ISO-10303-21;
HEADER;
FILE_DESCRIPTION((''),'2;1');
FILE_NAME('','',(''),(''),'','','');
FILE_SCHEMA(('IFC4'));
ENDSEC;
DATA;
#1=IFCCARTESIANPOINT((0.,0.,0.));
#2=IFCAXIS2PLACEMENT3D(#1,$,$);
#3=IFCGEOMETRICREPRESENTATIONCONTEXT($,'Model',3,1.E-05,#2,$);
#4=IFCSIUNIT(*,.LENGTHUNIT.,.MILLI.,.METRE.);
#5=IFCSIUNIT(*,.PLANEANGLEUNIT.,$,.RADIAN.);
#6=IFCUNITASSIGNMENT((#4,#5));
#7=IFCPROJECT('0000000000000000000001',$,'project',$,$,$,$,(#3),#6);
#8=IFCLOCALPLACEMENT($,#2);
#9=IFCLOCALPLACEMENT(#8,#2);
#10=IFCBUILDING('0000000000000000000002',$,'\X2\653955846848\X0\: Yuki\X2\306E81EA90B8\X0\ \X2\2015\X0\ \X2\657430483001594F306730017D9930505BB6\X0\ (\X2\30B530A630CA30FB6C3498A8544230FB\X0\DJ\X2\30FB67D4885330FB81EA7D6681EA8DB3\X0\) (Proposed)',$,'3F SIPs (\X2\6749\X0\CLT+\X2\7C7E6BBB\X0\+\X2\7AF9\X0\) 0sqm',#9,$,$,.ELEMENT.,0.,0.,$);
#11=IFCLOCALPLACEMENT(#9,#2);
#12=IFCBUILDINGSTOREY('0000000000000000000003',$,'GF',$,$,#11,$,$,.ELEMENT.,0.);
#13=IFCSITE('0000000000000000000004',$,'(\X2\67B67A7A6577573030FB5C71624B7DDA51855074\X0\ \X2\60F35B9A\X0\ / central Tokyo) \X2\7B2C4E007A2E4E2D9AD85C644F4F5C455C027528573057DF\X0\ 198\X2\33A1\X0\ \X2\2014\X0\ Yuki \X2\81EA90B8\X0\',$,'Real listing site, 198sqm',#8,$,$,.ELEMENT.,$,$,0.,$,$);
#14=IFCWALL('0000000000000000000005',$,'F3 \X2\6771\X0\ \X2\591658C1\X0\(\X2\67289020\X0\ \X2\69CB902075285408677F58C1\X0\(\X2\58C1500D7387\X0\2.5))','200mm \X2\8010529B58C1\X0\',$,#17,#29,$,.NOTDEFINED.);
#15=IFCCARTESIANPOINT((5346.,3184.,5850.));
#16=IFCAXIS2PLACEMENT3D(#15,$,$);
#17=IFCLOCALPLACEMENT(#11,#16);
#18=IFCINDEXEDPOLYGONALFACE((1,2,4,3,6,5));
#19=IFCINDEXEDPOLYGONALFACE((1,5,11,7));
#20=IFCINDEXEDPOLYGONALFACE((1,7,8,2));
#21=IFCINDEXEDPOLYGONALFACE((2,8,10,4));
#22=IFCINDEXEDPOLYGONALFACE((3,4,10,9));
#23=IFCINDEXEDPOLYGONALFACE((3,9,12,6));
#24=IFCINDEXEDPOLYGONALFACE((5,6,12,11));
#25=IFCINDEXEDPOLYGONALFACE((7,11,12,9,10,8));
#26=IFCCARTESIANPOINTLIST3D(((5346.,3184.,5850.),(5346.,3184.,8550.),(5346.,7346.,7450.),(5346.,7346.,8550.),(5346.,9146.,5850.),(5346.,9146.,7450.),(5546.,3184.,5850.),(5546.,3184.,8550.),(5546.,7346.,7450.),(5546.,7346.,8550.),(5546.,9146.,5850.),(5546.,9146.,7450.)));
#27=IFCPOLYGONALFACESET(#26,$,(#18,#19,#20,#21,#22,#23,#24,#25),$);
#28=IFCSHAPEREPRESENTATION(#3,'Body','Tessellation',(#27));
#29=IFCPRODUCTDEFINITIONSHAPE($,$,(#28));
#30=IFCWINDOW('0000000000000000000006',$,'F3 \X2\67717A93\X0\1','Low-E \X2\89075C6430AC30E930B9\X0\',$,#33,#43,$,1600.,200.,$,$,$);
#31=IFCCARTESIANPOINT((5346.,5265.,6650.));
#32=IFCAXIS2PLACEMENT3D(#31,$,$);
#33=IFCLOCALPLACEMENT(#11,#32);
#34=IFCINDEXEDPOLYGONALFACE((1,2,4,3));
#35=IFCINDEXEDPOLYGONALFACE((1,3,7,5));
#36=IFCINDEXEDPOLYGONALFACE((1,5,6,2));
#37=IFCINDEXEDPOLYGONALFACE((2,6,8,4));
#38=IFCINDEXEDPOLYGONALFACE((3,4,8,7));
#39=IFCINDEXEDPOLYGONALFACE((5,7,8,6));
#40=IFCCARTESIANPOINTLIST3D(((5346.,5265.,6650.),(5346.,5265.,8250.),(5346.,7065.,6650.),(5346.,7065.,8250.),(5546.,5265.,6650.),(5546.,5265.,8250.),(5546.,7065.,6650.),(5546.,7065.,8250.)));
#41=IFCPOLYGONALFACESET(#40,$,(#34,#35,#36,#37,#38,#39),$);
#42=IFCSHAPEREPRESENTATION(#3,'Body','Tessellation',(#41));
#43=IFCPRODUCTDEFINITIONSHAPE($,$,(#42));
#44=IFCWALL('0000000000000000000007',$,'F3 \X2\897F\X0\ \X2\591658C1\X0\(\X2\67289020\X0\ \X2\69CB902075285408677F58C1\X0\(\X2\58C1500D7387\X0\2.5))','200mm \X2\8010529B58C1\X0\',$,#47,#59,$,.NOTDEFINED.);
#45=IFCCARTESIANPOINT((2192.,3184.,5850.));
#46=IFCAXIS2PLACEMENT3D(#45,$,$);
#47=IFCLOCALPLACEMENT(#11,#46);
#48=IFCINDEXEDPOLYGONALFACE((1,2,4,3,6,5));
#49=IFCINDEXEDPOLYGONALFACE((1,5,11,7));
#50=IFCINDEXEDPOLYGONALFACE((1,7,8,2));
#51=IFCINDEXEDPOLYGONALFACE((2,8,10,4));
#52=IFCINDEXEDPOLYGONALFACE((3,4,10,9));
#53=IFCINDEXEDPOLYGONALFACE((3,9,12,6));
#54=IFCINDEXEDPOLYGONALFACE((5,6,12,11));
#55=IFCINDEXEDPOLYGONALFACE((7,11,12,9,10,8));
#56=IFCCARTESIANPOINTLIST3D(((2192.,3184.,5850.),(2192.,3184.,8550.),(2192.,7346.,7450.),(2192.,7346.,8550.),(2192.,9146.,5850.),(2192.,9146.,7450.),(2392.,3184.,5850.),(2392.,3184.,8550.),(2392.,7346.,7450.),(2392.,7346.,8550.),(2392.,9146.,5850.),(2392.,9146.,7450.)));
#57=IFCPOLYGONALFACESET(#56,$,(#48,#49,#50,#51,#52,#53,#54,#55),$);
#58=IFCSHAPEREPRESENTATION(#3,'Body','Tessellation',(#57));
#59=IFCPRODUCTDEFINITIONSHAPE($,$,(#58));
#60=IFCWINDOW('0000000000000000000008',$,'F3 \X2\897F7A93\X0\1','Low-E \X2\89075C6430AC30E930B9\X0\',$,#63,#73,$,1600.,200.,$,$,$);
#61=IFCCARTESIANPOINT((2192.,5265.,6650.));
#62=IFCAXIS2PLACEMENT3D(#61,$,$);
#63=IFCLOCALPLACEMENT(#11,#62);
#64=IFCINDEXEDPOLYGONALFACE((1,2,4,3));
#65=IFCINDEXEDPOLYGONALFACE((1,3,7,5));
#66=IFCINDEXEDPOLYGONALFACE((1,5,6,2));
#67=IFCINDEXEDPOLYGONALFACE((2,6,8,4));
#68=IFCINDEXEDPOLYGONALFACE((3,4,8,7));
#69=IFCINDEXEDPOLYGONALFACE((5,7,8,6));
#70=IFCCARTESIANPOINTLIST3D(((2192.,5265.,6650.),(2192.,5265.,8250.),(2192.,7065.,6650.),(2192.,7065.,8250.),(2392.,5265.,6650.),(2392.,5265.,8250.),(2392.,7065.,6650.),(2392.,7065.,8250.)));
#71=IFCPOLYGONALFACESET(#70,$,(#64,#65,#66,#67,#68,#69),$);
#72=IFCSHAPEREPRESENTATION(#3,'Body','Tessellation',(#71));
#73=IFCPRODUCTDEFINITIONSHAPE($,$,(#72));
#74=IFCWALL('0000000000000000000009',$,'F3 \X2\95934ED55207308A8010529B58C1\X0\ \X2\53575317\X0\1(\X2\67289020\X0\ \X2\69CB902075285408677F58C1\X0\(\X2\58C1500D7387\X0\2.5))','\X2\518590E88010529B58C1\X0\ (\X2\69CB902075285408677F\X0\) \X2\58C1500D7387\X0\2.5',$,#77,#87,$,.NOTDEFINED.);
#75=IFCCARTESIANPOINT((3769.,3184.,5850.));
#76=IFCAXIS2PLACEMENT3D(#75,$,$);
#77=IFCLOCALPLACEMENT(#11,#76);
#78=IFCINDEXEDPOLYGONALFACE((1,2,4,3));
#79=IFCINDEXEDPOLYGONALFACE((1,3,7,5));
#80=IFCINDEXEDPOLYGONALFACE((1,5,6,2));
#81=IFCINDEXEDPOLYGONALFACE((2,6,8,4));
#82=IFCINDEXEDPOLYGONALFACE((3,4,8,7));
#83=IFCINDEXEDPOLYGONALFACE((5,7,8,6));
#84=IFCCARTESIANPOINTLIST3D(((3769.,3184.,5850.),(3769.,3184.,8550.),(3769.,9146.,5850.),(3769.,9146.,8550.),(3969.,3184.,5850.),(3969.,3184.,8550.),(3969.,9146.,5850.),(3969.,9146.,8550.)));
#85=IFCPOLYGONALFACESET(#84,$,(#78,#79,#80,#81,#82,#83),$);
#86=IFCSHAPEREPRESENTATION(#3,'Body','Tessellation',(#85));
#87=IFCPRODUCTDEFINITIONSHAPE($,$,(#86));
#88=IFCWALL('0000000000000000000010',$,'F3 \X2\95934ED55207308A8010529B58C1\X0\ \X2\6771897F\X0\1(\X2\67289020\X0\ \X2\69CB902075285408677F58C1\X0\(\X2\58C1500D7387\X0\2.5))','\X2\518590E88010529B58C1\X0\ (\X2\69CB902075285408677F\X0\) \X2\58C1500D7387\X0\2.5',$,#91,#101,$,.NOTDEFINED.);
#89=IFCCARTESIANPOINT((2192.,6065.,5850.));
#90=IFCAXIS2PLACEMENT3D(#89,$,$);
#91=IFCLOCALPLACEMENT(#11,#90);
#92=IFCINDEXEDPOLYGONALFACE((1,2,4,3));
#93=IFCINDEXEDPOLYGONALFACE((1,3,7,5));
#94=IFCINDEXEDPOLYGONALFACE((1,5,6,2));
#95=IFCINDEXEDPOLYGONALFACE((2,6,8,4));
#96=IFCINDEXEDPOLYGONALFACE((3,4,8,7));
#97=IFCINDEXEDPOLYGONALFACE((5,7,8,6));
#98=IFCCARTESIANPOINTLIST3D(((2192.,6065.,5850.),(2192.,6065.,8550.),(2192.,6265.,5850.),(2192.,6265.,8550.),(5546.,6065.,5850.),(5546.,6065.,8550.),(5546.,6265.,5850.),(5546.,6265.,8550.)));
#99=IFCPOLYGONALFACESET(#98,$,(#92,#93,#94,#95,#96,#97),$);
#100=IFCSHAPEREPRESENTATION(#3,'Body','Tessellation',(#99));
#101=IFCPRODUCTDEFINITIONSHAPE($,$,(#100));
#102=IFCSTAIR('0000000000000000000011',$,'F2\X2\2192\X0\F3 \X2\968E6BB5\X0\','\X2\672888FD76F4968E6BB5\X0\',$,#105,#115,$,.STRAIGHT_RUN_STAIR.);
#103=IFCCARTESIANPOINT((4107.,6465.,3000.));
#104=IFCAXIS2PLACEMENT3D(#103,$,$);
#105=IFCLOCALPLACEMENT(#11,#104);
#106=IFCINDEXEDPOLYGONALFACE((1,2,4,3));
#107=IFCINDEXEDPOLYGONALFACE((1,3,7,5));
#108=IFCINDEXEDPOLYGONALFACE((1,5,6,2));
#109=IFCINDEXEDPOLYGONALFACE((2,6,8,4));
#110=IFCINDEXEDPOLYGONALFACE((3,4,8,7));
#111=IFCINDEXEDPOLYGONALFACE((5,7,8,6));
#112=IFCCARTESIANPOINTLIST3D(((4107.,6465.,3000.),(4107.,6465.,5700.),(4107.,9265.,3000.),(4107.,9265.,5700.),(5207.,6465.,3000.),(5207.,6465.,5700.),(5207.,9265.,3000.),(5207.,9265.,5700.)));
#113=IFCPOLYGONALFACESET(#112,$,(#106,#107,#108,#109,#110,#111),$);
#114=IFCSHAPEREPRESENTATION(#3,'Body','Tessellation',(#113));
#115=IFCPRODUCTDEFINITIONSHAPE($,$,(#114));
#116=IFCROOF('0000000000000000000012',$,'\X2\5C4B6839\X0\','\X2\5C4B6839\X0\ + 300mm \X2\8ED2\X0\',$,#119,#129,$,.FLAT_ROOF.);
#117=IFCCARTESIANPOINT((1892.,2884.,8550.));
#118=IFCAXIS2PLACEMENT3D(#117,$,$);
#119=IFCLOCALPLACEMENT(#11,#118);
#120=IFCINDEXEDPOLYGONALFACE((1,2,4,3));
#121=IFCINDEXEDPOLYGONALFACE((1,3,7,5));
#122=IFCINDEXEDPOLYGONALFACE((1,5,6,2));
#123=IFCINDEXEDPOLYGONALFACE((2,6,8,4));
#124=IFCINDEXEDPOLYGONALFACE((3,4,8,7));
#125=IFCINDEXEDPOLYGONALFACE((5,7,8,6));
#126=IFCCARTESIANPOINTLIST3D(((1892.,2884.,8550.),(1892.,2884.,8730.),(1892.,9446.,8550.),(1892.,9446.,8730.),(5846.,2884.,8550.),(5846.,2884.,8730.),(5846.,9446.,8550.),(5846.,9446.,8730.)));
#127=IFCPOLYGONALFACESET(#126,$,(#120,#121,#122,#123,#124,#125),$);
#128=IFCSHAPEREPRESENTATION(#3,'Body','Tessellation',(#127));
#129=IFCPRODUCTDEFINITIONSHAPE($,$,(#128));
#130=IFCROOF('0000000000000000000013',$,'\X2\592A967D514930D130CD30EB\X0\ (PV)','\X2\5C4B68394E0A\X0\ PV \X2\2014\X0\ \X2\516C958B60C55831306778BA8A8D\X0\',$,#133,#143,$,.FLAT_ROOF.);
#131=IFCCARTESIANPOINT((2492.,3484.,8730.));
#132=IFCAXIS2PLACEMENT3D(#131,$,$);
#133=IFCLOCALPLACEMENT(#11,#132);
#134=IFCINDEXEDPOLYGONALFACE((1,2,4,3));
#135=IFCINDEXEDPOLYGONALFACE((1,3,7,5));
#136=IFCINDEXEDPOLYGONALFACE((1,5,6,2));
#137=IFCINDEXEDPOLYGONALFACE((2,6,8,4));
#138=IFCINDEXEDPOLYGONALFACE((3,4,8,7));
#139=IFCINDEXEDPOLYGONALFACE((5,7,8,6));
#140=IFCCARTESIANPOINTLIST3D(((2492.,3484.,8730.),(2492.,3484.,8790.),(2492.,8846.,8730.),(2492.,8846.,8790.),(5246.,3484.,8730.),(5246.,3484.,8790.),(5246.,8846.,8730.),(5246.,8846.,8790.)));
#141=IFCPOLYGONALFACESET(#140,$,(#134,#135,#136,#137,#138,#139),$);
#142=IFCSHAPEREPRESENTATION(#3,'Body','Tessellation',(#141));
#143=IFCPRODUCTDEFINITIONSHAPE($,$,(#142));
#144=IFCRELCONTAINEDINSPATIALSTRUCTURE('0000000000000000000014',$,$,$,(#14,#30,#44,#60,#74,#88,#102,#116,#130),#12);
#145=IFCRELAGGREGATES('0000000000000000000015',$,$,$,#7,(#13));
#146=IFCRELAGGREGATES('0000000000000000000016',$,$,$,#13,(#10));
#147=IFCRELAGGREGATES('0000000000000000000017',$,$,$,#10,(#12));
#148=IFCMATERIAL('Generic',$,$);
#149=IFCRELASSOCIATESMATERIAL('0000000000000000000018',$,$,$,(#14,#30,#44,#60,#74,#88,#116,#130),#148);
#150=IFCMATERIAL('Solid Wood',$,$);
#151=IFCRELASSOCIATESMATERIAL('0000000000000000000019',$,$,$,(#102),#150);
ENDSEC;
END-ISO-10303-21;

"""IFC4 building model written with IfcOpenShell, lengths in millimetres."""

from ifc_helpers import new_model, si_unit, frame, frame_2d, origin, place, context, project, spatial, rectangle, extrude, material, element, fill, save


model = new_model("IFC4")

# Units and contexts
model_context = context("Model", 3, precision=1e-05, world=origin())
ifc_project = project(units=[si_unit("LENGTHUNIT", "METRE", prefix="MILLI"), si_unit("PLANEANGLEUNIT", "RADIAN")], contexts=[model_context])

# Site, building, storey
site_placement = place(None, origin())
site = spatial("IfcSite", under=ifc_project, at=site_placement, Name="(架空敷地・山手線内側 想定 / central Tokyo) 第一種中高層住居専用地域 198㎡ — Yuki 自邸", ObjectType="Real listing site, 198sqm", CompositionType="ELEMENT", RefElevation=0.0)
building_placement = place(site_placement, origin())
building = spatial("IfcBuilding", under=site, at=building_placement, Name="改善案: Yukiの自邸 ― 整え、奏で、継ぐ家 (サウナ・水風呂・DJ・柔術・自給自足) (Proposed)", ObjectType="3F SIPs (杉CLT+籾殻+竹) 0sqm", CompositionType="ELEMENT", ElevationOfRefHeight=0.0, ElevationOfTerrain=0.0)
storey_placement = place(building_placement, origin())
storey = spatial("IfcBuildingStorey", under=building, at=storey_placement, Name="GF", CompositionType="ELEMENT", Elevation=0.0)

# Shared definitions
ifc_material_1 = material(Name="Generic")

# Walls, openings, windows
wall_1_placement = place(storey_placement, frame((5346.0, 3184.0, 5850.0)))
wall_1 = element("IfcWall", 1, at=wall_1_placement, inside=storey, material=ifc_material_1, Name="F3 東 外壁(木造 構造用合板壁(壁倍率2.5))", Description="200mm 耐力壁", PredefinedType="NOTDEFINED", context=model_context, shape_type="SweptSolid", body=[
    extrude(rectangle(XDim=200.0, YDim=5962.0, at=frame_2d((100.0, 2981.0))), frame((5346.0, 3184.0, 5850.0)), (0.0, 0.0, 1.0), 2700.0),
])
opening_1_placement = place(storey_placement, frame((5346.0, 5265.0, 6650.0)))
opening_1 = element("IfcOpeningElement", 2, at=opening_1_placement, cuts=wall_1, PredefinedType="NOTDEFINED", context=model_context, shape_type="SweptSolid", body=[
    extrude(rectangle(XDim=200.0, YDim=1800.0, at=frame_2d((100.0, 900.0))), frame((5346.0, 5265.0, 6650.0)), (0.0, 0.0, 1.0), 1600.0),
])
window_1_placement = place(storey_placement, frame((5346.0, 5265.0, 6650.0)))
window_1 = element("IfcWindow", 3, at=window_1_placement, inside=storey, material=ifc_material_1, Name="F3 東窓1", Description="Low-E 複層ガラス", OverallHeight=1600.0, OverallWidth=200.0, context=model_context, shape_type="SweptSolid", body=[
    extrude(rectangle(XDim=200.0, YDim=1800.0, at=frame_2d((100.0, 900.0))), frame((5346.0, 5265.0, 6650.0)), (0.0, 0.0, 1.0), 1600.0),
])
fill(opening_1, window_1)
wall_2_placement = place(storey_placement, frame((2192.0, 3184.0, 5850.0)))
wall_2 = element("IfcWall", 4, at=wall_2_placement, inside=storey, material=ifc_material_1, Name="F3 西 外壁(木造 構造用合板壁(壁倍率2.5))", Description="200mm 耐力壁", PredefinedType="NOTDEFINED", context=model_context, shape_type="SweptSolid", body=[
    extrude(rectangle(XDim=200.0, YDim=5962.0, at=frame_2d((100.0, 2981.0))), frame((2192.0, 3184.0, 5850.0)), (0.0, 0.0, 1.0), 2700.0),
])
opening_2_placement = place(storey_placement, frame((2192.0, 5265.0, 6650.0)))
opening_2 = element("IfcOpeningElement", 5, at=opening_2_placement, cuts=wall_2, PredefinedType="NOTDEFINED", context=model_context, shape_type="SweptSolid", body=[
    extrude(rectangle(XDim=200.0, YDim=1800.0, at=frame_2d((100.0, 900.0))), frame((2192.0, 5265.0, 6650.0)), (0.0, 0.0, 1.0), 1600.0),
])
window_2_placement = place(storey_placement, frame((2192.0, 5265.0, 6650.0)))
window_2 = element("IfcWindow", 6, at=window_2_placement, inside=storey, material=ifc_material_1, Name="F3 西窓1", Description="Low-E 複層ガラス", OverallHeight=1600.0, OverallWidth=200.0, context=model_context, shape_type="SweptSolid", body=[
    extrude(rectangle(XDim=200.0, YDim=1800.0, at=frame_2d((100.0, 900.0))), frame((2192.0, 5265.0, 6650.0)), (0.0, 0.0, 1.0), 1600.0),
])
fill(opening_2, window_2)

# Walls
wall_3_placement = place(storey_placement, frame((3769.0, 3184.0, 5850.0)))
element("IfcWall", 7, at=wall_3_placement, inside=storey, material=ifc_material_1, Name="F3 間仕切り耐力壁 南北1(木造 構造用合板壁(壁倍率2.5))", Description="内部耐力壁 (構造用合板) 壁倍率2.5", PredefinedType="NOTDEFINED", context=model_context, shape_type="SweptSolid", body=[
    extrude(rectangle(XDim=200.0, YDim=5962.0, at=frame_2d((100.0, 2981.0))), frame((3769.0, 3184.0, 5850.0)), (0.0, 0.0, 1.0), 2700.0),
])
wall_4_placement = place(storey_placement, frame((2192.0, 6065.0, 5850.0)))
element("IfcWall", 8, at=wall_4_placement, inside=storey, material=ifc_material_1, Name="F3 間仕切り耐力壁 東西1(木造 構造用合板壁(壁倍率2.5))", Description="内部耐力壁 (構造用合板) 壁倍率2.5", PredefinedType="NOTDEFINED", context=model_context, shape_type="SweptSolid", body=[
    extrude(rectangle(XDim=3354.0, YDim=200.0, at=frame_2d((1677.0, 100.0))), frame((2192.0, 6065.0, 5850.0)), (0.0, 0.0, 1.0), 2700.0),
])

# Stair
ifc_material_2 = material(Name="Solid Wood")
stair_placement = place(storey_placement, frame((4107.0, 6465.0, 3000.0)))
element("IfcStair", 9, at=stair_placement, inside=storey, material=ifc_material_2, Name="F2→F3 階段", Description="木製直階段", PredefinedType="STRAIGHT_RUN_STAIR", context=model_context, shape_type="SweptSolid", body=[
    extrude(rectangle(XDim=1100.0, YDim=2800.0, at=frame_2d((550.0, 1400.0))), frame((4107.0, 6465.0, 3000.0)), (0.0, 0.0, 1.0), 2700.0),
])

# Roofs
roof_1_placement = place(storey_placement, frame((1892.0, 2884.0, 8550.0)))
element("IfcRoof", 10, at=roof_1_placement, inside=storey, material=ifc_material_1, Name="屋根", Description="屋根 + 300mm 軒", PredefinedType="FLAT_ROOF", context=model_context, shape_type="SweptSolid", body=[
    extrude(rectangle(XDim=3954.0, YDim=6562.0, at=frame_2d((1977.0, 3281.0))), frame((1892.0, 2884.0, 8550.0)), (0.0, 0.0, 1.0), 180.0),
])
roof_2_placement = place(storey_placement, frame((2492.0, 3484.0, 8730.0)))
element("IfcRoof", 11, at=roof_2_placement, inside=storey, material=ifc_material_1, Name="太陽光パネル (PV)", Description="屋根上 PV — 公開情報で確認", PredefinedType="FLAT_ROOF", context=model_context, shape_type="SweptSolid", body=[
    extrude(rectangle(XDim=2754.0, YDim=5362.0, at=frame_2d((1377.0, 2681.0))), frame((2492.0, 3484.0, 8730.0)), (0.0, 0.0, 1.0), 60.0),
])

save(model, "model.ifc")
